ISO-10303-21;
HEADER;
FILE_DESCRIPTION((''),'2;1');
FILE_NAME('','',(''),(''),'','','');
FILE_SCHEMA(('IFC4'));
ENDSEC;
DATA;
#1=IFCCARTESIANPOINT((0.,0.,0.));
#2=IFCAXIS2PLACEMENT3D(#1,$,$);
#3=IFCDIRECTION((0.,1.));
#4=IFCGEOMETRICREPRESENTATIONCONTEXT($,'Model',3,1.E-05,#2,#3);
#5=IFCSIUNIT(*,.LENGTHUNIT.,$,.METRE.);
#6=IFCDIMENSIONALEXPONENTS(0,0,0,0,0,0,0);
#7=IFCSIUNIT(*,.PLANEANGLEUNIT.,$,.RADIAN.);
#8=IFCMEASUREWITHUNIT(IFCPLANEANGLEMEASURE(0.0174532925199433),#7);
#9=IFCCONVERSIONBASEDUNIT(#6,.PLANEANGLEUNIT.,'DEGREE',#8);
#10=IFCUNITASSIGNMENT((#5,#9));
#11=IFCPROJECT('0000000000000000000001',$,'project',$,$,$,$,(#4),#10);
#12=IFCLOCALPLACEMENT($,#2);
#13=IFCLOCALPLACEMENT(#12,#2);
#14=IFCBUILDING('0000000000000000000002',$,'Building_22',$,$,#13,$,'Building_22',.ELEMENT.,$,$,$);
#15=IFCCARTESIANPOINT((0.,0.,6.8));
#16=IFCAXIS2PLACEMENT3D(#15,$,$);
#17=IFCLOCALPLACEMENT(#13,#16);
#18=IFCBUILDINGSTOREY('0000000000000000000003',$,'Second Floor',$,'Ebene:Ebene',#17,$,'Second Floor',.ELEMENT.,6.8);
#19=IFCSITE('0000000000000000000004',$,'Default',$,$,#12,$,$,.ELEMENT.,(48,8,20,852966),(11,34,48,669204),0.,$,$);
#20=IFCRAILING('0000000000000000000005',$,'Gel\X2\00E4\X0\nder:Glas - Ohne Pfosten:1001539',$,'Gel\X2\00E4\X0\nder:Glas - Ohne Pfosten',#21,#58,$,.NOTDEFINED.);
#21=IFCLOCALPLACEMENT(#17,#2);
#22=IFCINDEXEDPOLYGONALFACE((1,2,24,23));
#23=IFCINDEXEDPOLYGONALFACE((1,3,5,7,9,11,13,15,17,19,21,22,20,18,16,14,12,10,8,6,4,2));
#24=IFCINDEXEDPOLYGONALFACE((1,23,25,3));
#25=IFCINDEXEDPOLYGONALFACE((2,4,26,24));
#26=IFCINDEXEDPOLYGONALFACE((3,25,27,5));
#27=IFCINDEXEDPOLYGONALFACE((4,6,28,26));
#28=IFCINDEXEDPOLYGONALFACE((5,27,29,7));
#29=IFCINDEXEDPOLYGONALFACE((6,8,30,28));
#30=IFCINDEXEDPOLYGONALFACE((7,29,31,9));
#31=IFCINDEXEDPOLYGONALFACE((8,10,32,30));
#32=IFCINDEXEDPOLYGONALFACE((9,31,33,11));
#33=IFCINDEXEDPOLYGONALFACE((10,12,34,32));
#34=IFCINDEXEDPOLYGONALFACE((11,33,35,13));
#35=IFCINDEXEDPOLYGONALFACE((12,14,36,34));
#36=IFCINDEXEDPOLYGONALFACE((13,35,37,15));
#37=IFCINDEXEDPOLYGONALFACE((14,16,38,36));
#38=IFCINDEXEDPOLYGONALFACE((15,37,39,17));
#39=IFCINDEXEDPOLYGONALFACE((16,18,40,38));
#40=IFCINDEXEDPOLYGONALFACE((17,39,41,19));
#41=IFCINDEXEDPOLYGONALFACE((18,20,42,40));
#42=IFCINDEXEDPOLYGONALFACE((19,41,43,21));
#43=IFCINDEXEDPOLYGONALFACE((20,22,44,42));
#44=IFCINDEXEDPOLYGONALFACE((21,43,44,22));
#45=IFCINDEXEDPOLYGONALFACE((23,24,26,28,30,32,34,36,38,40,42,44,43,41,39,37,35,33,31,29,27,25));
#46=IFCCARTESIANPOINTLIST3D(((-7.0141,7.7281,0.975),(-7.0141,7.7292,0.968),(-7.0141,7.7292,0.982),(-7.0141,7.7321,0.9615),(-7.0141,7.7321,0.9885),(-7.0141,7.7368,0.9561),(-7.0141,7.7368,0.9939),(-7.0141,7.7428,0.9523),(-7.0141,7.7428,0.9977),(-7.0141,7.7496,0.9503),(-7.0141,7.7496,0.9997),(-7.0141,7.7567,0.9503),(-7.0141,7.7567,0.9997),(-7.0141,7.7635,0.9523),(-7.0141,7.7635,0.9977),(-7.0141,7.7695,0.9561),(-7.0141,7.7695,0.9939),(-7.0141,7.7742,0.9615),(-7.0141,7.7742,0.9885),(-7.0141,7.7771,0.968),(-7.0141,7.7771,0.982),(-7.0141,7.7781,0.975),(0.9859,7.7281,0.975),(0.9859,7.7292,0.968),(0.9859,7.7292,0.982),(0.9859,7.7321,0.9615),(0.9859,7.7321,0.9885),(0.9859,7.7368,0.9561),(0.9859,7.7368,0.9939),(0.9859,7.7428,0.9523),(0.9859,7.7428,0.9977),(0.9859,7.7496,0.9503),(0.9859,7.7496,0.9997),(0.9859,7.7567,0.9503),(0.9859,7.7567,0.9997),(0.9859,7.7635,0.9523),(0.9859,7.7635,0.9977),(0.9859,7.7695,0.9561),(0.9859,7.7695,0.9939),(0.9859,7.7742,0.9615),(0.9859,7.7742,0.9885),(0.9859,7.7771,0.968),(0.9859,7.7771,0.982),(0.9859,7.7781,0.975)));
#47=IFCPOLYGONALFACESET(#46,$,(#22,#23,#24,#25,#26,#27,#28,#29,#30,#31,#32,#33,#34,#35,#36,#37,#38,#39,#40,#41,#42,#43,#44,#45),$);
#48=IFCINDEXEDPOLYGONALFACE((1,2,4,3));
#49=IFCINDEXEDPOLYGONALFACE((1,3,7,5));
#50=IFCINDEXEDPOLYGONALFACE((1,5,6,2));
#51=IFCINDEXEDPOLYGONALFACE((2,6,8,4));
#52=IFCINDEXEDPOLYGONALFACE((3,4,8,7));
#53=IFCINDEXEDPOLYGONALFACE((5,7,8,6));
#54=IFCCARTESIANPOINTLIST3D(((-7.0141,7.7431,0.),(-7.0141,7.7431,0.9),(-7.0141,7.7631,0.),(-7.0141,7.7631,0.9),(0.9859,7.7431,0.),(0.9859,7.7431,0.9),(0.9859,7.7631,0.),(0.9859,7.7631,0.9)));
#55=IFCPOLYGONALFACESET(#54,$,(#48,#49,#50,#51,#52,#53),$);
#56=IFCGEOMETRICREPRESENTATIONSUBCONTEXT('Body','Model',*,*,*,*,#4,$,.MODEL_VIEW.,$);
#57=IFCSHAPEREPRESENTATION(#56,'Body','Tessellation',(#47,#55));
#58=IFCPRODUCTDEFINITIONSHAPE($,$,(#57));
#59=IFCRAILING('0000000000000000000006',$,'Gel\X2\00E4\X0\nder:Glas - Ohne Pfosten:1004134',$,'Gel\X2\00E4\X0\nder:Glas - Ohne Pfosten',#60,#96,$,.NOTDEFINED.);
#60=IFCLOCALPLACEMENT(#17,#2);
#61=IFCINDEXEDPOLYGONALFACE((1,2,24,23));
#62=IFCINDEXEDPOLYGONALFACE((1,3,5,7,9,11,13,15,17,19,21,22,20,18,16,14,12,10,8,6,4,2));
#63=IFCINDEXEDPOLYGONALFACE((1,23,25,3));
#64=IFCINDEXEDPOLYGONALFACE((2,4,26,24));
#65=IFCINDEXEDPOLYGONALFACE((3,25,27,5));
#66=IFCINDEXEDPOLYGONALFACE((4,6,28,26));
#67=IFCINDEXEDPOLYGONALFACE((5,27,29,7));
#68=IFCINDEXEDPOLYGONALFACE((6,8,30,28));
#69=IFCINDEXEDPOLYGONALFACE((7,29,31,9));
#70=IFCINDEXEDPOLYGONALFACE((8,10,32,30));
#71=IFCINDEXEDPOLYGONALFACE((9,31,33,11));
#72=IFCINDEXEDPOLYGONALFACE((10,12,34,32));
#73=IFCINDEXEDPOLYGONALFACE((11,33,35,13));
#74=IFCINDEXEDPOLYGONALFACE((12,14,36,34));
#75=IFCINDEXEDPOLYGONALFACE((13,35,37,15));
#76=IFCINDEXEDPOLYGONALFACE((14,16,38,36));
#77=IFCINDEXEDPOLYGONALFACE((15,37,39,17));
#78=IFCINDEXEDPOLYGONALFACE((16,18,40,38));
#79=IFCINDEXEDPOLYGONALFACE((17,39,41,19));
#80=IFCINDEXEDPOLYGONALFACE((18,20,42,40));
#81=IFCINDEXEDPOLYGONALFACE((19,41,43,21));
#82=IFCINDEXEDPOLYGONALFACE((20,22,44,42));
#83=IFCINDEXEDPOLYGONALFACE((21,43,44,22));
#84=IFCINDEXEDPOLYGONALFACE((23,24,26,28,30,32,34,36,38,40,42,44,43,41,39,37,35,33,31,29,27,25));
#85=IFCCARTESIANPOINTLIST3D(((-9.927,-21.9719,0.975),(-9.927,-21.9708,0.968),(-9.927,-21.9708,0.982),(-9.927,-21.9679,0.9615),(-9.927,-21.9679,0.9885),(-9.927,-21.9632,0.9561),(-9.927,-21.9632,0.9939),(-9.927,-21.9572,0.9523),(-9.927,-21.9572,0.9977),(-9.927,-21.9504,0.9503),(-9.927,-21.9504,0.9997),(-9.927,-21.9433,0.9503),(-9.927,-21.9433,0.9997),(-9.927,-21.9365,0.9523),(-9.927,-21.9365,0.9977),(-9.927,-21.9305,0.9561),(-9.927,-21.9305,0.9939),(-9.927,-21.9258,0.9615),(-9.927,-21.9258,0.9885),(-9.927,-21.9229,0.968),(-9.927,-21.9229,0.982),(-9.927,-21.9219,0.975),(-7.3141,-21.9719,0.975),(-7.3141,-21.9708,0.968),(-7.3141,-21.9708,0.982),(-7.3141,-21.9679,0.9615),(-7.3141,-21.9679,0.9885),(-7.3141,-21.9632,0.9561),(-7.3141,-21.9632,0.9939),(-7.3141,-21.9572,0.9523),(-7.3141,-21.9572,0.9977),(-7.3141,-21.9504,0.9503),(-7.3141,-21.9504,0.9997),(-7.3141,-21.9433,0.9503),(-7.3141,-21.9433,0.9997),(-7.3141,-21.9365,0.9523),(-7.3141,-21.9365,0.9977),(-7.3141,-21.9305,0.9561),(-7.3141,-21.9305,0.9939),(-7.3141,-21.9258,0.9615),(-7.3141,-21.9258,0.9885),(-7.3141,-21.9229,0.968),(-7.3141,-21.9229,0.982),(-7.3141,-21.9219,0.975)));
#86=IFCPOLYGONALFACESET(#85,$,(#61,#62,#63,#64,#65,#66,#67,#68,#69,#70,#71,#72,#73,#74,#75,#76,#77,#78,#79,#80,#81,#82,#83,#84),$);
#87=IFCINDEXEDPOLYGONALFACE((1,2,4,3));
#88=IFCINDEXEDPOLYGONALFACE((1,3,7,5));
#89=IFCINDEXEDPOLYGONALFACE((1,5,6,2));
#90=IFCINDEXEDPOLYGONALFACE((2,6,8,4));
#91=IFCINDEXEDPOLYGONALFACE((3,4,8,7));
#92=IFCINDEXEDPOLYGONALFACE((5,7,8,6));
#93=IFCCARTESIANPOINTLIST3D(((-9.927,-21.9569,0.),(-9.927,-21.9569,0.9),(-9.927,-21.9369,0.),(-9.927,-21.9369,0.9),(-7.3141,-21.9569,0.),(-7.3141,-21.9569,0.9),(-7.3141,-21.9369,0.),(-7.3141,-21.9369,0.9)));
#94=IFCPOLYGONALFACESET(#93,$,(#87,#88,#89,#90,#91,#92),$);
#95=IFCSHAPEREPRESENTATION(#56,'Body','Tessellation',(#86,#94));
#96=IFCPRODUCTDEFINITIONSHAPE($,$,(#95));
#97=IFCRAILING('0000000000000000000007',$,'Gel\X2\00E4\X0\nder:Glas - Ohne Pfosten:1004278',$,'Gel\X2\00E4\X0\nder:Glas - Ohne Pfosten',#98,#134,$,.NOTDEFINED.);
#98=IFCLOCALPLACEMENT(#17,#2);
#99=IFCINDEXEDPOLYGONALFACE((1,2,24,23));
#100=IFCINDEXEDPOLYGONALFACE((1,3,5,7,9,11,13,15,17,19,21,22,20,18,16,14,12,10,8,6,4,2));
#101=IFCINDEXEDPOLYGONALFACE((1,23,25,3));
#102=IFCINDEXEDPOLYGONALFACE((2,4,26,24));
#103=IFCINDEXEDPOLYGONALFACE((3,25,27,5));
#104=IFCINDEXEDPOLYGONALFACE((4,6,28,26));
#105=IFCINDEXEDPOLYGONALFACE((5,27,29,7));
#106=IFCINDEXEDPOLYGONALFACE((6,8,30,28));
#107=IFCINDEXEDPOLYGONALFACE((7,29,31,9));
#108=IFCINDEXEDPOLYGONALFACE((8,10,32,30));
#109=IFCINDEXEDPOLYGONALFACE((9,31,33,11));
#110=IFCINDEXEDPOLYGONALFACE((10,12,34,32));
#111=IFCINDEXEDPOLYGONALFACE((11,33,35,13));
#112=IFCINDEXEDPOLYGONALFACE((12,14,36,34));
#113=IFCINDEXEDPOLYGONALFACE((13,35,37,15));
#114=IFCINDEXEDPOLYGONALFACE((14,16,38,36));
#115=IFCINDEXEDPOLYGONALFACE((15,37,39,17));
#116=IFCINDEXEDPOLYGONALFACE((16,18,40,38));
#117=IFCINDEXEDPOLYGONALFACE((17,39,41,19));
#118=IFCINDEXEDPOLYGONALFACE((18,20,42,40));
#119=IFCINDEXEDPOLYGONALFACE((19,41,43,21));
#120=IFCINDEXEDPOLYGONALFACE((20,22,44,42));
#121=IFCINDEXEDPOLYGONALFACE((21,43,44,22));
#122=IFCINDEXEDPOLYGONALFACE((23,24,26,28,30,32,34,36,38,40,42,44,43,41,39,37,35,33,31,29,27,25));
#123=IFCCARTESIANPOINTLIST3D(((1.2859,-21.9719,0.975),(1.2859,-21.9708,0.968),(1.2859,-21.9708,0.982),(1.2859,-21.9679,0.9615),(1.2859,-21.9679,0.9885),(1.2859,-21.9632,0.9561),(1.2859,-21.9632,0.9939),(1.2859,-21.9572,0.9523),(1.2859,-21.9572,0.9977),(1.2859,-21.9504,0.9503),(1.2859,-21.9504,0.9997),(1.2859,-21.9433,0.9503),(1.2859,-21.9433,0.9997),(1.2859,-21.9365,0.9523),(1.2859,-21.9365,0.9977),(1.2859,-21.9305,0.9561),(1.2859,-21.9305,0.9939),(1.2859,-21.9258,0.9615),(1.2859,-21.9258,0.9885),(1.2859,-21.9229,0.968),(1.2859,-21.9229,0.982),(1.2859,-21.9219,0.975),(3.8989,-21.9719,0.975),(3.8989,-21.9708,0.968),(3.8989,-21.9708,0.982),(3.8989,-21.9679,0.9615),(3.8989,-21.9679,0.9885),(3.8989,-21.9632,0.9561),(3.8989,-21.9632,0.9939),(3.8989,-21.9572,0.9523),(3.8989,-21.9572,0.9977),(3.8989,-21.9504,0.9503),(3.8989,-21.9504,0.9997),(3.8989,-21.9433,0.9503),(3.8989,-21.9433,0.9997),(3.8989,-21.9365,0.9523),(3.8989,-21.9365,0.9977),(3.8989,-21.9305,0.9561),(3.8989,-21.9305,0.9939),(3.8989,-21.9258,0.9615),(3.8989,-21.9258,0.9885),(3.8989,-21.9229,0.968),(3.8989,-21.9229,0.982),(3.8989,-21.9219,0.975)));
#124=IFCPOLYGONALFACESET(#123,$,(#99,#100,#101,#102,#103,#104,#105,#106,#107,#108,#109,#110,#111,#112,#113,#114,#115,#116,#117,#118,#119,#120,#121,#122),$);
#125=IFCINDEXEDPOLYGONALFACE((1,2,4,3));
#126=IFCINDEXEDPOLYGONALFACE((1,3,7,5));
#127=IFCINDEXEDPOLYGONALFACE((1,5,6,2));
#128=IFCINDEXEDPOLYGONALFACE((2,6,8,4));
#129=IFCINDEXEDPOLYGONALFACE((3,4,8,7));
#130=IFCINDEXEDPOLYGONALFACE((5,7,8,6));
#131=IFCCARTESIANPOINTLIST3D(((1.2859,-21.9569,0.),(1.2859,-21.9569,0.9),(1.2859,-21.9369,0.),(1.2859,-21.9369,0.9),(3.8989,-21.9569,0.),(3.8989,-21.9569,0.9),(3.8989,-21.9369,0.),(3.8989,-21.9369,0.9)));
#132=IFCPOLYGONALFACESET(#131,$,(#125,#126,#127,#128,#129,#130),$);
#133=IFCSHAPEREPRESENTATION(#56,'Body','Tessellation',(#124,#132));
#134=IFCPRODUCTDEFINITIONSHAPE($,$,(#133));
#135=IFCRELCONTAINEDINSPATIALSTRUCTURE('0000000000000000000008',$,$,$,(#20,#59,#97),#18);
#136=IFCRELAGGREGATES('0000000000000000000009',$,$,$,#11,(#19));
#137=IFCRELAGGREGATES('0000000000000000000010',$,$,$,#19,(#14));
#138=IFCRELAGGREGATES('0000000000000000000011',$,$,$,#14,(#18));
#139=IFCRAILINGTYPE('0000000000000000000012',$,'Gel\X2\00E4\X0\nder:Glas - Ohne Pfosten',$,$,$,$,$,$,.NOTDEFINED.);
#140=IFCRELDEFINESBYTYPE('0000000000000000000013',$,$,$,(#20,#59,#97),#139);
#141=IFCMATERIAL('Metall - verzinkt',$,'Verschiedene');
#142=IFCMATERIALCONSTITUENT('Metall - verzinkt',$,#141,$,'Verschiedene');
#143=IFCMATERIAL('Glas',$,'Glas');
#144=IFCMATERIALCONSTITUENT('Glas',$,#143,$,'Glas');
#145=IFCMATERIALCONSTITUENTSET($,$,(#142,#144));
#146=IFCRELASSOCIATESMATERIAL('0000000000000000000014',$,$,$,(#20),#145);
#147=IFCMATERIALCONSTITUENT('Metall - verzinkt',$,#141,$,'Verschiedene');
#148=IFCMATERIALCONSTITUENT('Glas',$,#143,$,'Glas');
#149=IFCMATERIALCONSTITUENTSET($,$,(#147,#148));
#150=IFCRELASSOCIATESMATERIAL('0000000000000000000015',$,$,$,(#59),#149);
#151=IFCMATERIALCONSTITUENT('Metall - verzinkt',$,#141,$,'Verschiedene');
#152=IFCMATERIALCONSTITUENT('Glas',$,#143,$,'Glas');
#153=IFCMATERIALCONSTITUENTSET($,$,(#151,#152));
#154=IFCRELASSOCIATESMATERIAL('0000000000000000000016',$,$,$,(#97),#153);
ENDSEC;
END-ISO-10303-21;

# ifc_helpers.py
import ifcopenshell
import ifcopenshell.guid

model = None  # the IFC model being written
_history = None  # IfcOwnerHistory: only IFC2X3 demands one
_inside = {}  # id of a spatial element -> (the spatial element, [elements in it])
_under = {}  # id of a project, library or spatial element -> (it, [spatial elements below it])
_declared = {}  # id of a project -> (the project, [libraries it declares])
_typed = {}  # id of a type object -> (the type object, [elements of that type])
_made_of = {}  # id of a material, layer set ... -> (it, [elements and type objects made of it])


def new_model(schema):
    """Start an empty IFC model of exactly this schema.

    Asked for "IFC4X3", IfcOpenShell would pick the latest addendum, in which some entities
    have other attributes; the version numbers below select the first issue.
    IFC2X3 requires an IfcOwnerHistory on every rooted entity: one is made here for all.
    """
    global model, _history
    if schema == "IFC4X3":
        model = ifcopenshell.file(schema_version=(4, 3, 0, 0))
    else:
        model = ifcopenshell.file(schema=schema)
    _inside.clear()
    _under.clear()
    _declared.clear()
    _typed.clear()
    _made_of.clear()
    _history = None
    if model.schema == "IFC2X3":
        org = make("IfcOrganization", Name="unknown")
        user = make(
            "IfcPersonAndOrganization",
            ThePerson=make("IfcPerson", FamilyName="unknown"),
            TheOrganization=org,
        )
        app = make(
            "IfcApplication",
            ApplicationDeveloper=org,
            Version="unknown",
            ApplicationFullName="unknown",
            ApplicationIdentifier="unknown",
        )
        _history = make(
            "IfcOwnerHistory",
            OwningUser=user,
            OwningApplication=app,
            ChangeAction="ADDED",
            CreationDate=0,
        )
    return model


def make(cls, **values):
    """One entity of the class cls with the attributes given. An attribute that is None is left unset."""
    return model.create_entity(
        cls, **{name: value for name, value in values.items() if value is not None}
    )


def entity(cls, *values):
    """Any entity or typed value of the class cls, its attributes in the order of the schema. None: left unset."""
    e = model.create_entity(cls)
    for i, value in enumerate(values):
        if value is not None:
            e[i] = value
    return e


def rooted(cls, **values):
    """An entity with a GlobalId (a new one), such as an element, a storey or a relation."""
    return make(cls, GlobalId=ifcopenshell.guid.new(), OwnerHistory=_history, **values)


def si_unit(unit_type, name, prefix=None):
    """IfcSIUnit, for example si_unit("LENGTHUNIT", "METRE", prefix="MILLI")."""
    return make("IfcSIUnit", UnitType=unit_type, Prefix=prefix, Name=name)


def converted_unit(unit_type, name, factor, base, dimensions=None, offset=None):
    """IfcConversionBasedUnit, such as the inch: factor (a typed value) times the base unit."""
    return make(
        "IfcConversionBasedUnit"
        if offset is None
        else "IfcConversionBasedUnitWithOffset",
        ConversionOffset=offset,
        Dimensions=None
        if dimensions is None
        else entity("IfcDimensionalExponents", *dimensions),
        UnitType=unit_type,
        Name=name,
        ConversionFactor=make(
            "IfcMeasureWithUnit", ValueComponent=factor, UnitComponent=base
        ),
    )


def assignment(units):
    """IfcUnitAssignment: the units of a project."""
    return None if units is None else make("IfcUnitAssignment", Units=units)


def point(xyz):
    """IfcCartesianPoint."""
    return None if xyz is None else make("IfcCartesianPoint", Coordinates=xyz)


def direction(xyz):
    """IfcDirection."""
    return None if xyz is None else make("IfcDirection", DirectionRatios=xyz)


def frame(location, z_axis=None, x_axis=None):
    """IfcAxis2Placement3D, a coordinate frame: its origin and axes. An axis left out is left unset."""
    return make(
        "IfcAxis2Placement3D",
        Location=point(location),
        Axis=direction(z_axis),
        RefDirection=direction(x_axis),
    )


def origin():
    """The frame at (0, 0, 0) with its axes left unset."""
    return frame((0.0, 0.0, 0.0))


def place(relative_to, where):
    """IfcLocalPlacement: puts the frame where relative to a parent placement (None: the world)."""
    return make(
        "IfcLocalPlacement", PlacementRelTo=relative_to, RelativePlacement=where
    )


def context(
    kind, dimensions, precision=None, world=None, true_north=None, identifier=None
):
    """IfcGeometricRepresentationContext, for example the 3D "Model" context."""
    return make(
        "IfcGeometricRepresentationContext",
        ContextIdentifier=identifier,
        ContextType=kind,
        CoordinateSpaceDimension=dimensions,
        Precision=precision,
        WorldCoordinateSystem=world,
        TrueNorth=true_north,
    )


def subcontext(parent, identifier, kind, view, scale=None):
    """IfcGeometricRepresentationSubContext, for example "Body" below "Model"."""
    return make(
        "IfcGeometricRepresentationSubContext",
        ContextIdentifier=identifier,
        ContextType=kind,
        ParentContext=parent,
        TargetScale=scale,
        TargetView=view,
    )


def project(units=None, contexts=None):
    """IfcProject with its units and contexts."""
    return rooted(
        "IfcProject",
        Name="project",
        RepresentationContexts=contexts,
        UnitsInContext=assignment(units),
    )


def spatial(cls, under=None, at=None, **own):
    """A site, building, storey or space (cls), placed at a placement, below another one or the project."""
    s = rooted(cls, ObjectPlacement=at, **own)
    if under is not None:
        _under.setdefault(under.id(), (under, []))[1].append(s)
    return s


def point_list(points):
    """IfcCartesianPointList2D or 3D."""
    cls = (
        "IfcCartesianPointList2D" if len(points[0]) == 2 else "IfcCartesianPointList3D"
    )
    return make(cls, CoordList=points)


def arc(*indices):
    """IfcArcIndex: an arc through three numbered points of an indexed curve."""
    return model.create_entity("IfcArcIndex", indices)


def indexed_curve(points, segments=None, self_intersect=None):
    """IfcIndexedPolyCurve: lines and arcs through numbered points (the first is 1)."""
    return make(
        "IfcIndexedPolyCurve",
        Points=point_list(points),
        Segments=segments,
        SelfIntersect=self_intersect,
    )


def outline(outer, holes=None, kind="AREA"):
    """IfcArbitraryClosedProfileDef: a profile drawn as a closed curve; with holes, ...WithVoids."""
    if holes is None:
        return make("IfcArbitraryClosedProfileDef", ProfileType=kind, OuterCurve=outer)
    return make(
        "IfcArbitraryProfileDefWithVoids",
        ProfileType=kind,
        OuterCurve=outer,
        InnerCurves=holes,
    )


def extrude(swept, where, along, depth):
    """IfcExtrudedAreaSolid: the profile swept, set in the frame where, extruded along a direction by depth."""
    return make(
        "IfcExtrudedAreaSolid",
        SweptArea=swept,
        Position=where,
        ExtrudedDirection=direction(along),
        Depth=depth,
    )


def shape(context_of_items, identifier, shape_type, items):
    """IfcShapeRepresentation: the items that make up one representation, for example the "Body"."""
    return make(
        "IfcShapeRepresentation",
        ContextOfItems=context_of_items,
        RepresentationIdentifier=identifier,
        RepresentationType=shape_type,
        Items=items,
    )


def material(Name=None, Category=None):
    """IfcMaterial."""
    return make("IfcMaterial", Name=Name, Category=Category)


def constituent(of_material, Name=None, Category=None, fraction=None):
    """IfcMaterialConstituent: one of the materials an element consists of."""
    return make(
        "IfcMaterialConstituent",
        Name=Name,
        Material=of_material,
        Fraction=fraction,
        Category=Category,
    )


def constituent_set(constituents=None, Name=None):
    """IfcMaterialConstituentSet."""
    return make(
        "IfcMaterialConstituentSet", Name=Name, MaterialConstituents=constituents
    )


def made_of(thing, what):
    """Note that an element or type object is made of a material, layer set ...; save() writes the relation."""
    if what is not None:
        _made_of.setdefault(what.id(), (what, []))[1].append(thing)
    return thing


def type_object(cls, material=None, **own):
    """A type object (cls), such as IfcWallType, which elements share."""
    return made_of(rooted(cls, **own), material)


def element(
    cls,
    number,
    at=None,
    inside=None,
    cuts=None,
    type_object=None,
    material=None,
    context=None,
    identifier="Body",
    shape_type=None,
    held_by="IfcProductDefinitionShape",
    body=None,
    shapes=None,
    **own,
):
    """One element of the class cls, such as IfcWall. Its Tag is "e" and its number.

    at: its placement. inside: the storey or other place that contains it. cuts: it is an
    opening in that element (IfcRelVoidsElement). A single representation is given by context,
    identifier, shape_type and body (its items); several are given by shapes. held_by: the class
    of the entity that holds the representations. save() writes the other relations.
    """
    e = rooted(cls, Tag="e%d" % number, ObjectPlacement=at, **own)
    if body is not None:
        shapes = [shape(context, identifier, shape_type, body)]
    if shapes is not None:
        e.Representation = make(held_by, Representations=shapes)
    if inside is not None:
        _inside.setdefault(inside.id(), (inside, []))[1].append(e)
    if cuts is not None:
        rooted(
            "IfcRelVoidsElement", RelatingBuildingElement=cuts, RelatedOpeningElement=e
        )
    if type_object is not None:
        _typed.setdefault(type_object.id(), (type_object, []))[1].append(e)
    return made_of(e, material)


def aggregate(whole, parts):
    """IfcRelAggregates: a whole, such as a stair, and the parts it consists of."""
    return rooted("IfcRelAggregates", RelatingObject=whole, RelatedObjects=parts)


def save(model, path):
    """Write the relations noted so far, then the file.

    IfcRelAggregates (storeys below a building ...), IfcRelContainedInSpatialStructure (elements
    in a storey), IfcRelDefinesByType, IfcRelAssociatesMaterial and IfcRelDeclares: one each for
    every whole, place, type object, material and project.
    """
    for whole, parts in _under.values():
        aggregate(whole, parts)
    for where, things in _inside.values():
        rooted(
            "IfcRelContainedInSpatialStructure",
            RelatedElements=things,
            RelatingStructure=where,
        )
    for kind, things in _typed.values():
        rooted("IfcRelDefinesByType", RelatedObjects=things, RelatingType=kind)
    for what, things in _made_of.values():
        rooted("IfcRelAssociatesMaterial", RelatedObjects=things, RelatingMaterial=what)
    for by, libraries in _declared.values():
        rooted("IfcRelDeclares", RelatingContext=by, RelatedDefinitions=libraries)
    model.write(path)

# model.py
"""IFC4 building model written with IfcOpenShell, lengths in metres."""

from ifc_helpers import new_model, entity, si_unit, converted_unit, direction, frame, origin, place, context, subcontext, project, spatial, arc, indexed_curve, outline, extrude, material, constituent, constituent_set, type_object, element, save


model = new_model("IFC4")

# Units and contexts
model_context = context("Model", 3, precision=1e-05, world=origin(), true_north=direction((0.0, 1.0)))
body_context = subcontext(model_context, "Body", "Model", "MODEL_VIEW")
ifc_project = project(units=[si_unit("LENGTHUNIT", "METRE"), converted_unit("PLANEANGLEUNIT", "DEGREE", entity("IfcPlaneAngleMeasure", 0.0174532925199433), si_unit("PLANEANGLEUNIT", "RADIAN"), dimensions=[0, 0, 0, 0, 0, 0, 0])], contexts=[model_context])

# Site, building, storey
site_placement = place(None, origin())
site = spatial("IfcSite", under=ifc_project, at=site_placement, Name="Default", CompositionType="ELEMENT", RefLatitude=(48, 8, 20, 852966), RefLongitude=(11, 34, 48, 669204), RefElevation=0.0)
building_placement = place(site_placement, origin())
building = spatial("IfcBuilding", under=site, at=building_placement, Name="Building_22", LongName="Building_22", CompositionType="ELEMENT")
storey_placement = place(building_placement, frame((0.0, 0.0, 6.8)))
storey = spatial("IfcBuildingStorey", under=building, at=storey_placement, Name="Second Floor", ObjectType="Ebene:Ebene", LongName="Second Floor", CompositionType="ELEMENT", Elevation=6.8)

# Shared definitions
ifc_material_1 = material(Name="Metall - verzinkt", Category="Verschiedene")

# Shared definitions
ifc_material_2 = material(Name="Glas", Category="Glas")

# Railings
railing_type = type_object("IfcRailingType", Name="Geländer:Glas - Ohne Pfosten", PredefinedType="NOTDEFINED")
ifc_constituent_1 = constituent(ifc_material_1, Name="Metall - verzinkt", Category="Verschiedene")
ifc_constituent_2 = constituent(ifc_material_2, Name="Glas", Category="Glas")
ifc_constituent_set_1 = constituent_set(constituents=[ifc_constituent_1, ifc_constituent_2])
railing_1_placement = place(storey_placement, origin())
element("IfcRailing", 1, at=railing_1_placement, inside=storey, type_object=railing_type, material=ifc_constituent_set_1, Name="Geländer:Glas - Ohne Pfosten:1001539", ObjectType="Geländer:Glas - Ohne Pfosten", PredefinedType="NOTDEFINED", context=body_context, shape_type="SweptSolid", body=[
    extrude(outline(indexed_curve([(-0.025, 0.0), (0.0, -0.025), (0.025, 0.0), (0.0, 0.025)], segments=[arc(1, 2, 3), arc(3, 4, 1)], self_intersect=False)), frame((-7.0141, 7.7531, 0.975), z_axis=(1.0, 0.0, 0.0), x_axis=(0.0, -1.0, 0.0)), (0.0, 0.0, 1.0), 8.0),
    extrude(outline(indexed_curve([(-4.0, -0.01), (4.0, -0.01), (4.0, 0.01), (-4.0, 0.01), (-4.0, -0.01)], self_intersect=False)), frame((-3.0141, 7.7531, 0.0)), (0.0, 0.0, 1.0), 0.9),
])
ifc_constituent_3 = constituent(ifc_material_1, Name="Metall - verzinkt", Category="Verschiedene")
ifc_constituent_4 = constituent(ifc_material_2, Name="Glas", Category="Glas")
ifc_constituent_set_2 = constituent_set(constituents=[ifc_constituent_3, ifc_constituent_4])
railing_2_placement = place(storey_placement, origin())
element("IfcRailing", 2, at=railing_2_placement, inside=storey, type_object=railing_type, material=ifc_constituent_set_2, Name="Geländer:Glas - Ohne Pfosten:1004134", ObjectType="Geländer:Glas - Ohne Pfosten", PredefinedType="NOTDEFINED", context=body_context, shape_type="SweptSolid", body=[
    extrude(outline(indexed_curve([(-0.025, 0.0), (0.0, -0.025), (0.025, 0.0), (0.0, 0.025)], segments=[arc(1, 2, 3), arc(3, 4, 1)], self_intersect=False)), frame((-9.927, -21.9469, 0.975), z_axis=(1.0, 0.0, 0.0), x_axis=(0.0, 1.0, 0.0)), (0.0, 0.0, 1.0), 2.6129),
    extrude(outline(indexed_curve([(-1.3065, -0.01), (1.3065, -0.01), (1.3065, 0.01), (-1.3065, 0.01), (-1.3065, -0.01)], self_intersect=False)), frame((-8.6205, -21.9469, 0.0), z_axis=(0.0, 0.0, 1.0), x_axis=(-1.0, 0.0, 0.0)), (0.0, 0.0, 1.0), 0.9),
])
ifc_constituent_5 = constituent(ifc_material_1, Name="Metall - verzinkt", Category="Verschiedene")
ifc_constituent_6 = constituent(ifc_material_2, Name="Glas", Category="Glas")
ifc_constituent_set_3 = constituent_set(constituents=[ifc_constituent_5, ifc_constituent_6])
railing_3_placement = place(storey_placement, origin())
element("IfcRailing", 3, at=railing_3_placement, inside=storey, type_object=railing_type, material=ifc_constituent_set_3, Name="Geländer:Glas - Ohne Pfosten:1004278", ObjectType="Geländer:Glas - Ohne Pfosten", PredefinedType="NOTDEFINED", context=body_context, shape_type="SweptSolid", body=[
    extrude(outline(indexed_curve([(-0.025, 0.0), (0.0, -0.025), (0.025, 0.0), (0.0, 0.025)], segments=[arc(1, 2, 3), arc(3, 4, 1)], self_intersect=False)), frame((1.2859, -21.9469, 0.975), z_axis=(1.0, 0.0, 0.0), x_axis=(0.0, 1.0, 0.0)), (0.0, 0.0, 1.0), 2.6129),
    extrude(outline(indexed_curve([(-1.3065, -0.01), (1.3065, -0.01), (1.3065, 0.01), (-1.3065, 0.01), (-1.3065, -0.01)], self_intersect=False)), frame((2.5924, -21.9469, 0.0)), (0.0, 0.0, 1.0), 0.9),
])

save(model, "model.ifc")
